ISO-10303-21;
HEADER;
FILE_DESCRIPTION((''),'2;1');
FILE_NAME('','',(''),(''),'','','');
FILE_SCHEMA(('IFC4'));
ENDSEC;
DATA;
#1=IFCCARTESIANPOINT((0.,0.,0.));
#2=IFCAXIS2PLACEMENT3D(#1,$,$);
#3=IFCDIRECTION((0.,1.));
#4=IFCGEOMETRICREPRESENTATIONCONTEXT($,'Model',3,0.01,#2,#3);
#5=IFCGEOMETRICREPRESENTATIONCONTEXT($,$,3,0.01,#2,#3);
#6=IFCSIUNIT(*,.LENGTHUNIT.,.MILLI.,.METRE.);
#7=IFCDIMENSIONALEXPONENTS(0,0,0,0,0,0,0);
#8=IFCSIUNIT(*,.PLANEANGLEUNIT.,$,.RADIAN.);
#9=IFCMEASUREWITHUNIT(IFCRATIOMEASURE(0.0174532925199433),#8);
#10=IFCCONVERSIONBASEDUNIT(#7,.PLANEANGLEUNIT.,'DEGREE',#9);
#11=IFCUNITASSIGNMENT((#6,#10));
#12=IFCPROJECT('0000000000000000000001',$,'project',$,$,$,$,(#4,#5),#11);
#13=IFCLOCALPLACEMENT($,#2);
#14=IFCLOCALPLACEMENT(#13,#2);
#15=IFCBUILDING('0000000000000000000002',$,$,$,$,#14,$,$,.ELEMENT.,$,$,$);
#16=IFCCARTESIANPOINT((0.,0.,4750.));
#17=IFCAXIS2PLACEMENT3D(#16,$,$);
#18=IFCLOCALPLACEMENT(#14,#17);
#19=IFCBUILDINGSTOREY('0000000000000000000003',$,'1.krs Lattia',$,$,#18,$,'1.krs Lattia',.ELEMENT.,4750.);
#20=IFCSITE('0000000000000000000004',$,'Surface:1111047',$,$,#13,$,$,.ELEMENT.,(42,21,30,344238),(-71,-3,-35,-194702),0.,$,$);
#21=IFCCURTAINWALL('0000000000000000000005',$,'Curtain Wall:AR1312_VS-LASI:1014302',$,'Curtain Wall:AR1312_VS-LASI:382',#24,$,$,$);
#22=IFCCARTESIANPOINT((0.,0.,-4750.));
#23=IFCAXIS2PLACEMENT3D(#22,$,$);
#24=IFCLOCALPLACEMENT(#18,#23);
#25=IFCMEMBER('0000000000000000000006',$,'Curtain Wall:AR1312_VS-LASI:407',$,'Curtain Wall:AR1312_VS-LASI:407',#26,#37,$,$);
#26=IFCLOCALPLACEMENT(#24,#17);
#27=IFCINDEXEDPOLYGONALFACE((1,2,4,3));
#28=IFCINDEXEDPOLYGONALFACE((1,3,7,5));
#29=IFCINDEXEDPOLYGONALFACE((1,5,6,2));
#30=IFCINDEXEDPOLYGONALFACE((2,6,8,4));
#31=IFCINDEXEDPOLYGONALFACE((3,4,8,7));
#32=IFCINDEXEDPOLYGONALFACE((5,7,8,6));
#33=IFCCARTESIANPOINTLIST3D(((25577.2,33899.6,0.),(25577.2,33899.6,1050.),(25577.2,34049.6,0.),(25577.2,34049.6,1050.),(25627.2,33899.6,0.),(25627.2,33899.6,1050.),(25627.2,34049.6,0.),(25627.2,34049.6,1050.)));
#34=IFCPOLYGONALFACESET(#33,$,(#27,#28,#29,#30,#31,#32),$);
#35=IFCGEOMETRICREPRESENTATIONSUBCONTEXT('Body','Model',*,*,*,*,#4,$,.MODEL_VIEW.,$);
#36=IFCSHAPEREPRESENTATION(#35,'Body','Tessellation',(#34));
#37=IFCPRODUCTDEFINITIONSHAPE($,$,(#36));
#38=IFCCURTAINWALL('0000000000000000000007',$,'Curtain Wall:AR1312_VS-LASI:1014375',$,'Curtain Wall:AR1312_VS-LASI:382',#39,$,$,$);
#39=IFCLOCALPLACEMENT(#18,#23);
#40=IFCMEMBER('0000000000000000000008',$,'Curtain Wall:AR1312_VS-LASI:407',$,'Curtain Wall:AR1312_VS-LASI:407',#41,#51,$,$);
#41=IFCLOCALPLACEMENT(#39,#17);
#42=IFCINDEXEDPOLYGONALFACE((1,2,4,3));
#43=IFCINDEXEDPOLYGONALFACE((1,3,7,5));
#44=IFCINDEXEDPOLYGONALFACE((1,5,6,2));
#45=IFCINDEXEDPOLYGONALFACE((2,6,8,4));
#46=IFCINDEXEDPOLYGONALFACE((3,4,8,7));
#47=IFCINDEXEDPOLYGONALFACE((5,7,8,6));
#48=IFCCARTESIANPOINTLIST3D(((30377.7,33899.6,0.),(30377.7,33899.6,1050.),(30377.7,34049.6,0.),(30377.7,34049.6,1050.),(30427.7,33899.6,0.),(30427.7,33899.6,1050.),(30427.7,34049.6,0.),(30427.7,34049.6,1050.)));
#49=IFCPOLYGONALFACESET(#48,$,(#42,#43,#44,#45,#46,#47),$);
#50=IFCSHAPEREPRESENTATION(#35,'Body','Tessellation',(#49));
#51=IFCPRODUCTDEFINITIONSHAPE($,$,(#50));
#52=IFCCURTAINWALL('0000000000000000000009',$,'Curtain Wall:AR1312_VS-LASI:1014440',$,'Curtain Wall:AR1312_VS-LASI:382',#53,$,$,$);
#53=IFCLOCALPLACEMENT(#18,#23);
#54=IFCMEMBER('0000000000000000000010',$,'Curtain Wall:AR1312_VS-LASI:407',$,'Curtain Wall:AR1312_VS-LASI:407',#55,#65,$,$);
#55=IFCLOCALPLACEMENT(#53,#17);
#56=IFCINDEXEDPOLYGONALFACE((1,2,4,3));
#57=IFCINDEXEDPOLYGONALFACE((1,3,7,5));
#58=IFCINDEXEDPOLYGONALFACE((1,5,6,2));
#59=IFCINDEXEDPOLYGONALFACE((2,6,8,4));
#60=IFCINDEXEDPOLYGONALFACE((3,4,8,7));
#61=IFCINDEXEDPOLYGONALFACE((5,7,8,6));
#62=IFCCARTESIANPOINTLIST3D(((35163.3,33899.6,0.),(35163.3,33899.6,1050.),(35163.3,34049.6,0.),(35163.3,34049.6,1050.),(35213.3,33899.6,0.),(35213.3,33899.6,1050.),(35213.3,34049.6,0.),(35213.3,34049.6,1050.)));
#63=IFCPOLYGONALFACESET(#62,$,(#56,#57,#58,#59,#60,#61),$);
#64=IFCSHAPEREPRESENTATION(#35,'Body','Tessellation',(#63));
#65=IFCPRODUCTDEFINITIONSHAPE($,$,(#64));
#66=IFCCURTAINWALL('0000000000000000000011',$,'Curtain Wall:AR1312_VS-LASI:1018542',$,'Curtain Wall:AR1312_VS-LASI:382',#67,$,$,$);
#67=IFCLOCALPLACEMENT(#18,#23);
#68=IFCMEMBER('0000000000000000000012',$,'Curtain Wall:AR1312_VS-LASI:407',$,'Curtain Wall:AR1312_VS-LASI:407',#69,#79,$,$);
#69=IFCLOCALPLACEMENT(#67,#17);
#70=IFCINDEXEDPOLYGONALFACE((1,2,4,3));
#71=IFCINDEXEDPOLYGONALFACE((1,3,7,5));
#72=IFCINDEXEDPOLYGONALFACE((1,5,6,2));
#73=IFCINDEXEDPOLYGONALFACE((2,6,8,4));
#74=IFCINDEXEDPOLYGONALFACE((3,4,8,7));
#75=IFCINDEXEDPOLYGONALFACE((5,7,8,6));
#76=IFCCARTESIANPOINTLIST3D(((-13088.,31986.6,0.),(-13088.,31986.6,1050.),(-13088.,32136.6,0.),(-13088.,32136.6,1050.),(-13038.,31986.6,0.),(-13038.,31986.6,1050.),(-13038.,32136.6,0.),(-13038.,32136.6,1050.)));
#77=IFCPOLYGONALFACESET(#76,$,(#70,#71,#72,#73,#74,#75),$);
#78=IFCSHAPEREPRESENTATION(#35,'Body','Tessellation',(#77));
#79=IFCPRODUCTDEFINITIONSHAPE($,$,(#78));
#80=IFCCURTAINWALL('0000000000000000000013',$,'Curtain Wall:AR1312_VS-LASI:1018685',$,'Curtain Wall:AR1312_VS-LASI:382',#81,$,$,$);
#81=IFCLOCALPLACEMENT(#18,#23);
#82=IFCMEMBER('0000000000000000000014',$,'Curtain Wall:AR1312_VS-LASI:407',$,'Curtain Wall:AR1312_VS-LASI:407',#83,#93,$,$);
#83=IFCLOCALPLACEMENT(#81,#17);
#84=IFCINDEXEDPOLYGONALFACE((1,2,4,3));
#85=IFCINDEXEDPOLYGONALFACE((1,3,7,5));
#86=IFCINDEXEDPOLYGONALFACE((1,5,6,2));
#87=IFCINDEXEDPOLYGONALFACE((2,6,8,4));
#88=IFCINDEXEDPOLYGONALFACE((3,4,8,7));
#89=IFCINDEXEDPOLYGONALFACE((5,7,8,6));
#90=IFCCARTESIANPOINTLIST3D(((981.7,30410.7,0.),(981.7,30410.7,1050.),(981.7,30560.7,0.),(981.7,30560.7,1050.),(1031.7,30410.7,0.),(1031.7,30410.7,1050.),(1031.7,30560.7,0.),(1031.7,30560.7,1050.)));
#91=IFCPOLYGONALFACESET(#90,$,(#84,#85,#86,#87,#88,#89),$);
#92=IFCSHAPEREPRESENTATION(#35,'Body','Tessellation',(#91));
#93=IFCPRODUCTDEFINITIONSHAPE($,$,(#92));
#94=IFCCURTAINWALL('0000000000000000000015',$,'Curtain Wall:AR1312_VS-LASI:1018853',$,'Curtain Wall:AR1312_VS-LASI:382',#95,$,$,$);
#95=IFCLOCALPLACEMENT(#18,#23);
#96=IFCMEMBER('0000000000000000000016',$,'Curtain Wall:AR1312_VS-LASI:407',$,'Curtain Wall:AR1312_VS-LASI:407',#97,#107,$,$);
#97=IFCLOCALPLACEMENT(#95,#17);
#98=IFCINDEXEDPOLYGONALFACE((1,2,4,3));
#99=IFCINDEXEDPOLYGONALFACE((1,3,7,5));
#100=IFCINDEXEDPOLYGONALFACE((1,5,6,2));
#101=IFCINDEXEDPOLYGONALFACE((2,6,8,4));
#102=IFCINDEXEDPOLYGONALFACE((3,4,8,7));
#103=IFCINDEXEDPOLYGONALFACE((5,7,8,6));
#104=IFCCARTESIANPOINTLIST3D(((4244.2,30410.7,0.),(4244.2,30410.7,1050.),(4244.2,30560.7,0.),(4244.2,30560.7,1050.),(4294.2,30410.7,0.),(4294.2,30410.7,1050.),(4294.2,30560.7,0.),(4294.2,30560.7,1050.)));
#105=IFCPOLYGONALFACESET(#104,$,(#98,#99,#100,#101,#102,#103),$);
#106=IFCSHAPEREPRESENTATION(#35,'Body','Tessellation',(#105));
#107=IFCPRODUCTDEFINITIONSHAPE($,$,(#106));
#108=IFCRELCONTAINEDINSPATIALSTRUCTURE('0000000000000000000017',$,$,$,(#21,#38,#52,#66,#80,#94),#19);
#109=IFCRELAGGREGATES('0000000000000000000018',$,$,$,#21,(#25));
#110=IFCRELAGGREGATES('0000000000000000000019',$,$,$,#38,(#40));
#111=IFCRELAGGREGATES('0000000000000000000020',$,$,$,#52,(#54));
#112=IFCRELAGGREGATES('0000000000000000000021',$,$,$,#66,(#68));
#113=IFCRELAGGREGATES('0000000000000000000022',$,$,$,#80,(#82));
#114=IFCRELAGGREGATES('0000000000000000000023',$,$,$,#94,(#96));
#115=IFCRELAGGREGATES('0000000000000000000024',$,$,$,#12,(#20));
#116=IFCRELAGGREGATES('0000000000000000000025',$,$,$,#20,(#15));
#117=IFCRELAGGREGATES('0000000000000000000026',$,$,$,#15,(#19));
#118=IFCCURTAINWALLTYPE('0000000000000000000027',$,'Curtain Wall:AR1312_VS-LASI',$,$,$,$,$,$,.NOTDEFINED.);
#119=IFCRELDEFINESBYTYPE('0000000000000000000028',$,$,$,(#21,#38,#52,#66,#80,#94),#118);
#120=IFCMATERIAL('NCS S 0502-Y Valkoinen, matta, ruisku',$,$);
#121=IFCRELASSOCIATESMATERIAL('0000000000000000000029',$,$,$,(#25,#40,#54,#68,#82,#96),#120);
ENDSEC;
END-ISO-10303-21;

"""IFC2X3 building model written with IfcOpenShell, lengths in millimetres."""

from ifc_helpers import new_model, entity, si_unit, converted_unit, direction, frame, frame_2d, origin, origin_2d_with_axis, place, context, subcontext, project, spatial, rectangle, extrude, material, type_object, element, aggregate, save


model = new_model("IFC2X3")

# Units and contexts
model_context = context("Model", 3, precision=0.01, world=origin(), true_north=direction((0.0, 1.0)))
context_of_model = context(None, 3, precision=0.01, world=origin(), true_north=direction((0.0, 1.0)))
body_context = subcontext(model_context, "Body", "Model", "MODEL_VIEW")
ifc_project = project(units=[si_unit("LENGTHUNIT", "METRE", prefix="MILLI"), converted_unit("PLANEANGLEUNIT", "DEGREE", entity("IfcRatioMeasure", 0.0174532925199433), si_unit("PLANEANGLEUNIT", "RADIAN"), dimensions=[0, 0, 0, 0, 0, 0, 0])], contexts=[model_context, context_of_model])

# Site, building, storey
site_placement = place(None, origin())
site = spatial("IfcSite", under=ifc_project, at=site_placement, Name="Surface:1111047", CompositionType="ELEMENT", RefLatitude=(42, 21, 30, 344238), RefLongitude=(-71, -3, -35, -194702), RefElevation=0.0)
building_placement = place(site_placement, origin())
building = spatial("IfcBuilding", under=site, at=building_placement, CompositionType="ELEMENT")
storey_placement = place(building_placement, frame((0.0, 0.0, 4750.0)))
storey = spatial("IfcBuildingStorey", under=building, at=storey_placement, Name="1.krs Lattia", LongName="1.krs Lattia", CompositionType="ELEMENT", Elevation=4750.0)

# Curtain walls, members
curtain_wall_type = type_object("IfcCurtainWallType", Name="Curtain Wall:AR1312_VS-LASI", PredefinedType="NOTDEFINED")
curtain_wall_1_placement = place(storey_placement, frame((0.0, 0.0, -4750.0)))
curtain_wall_1 = element("IfcCurtainWall", 1, at=curtain_wall_1_placement, inside=storey, type_object=curtain_wall_type, Name="Curtain Wall:AR1312_VS-LASI:1014302", ObjectType="Curtain Wall:AR1312_VS-LASI:382")
ifc_material = material(Name="NCS S 0502-Y Valkoinen, matta, ruisku")
member_1_placement = place(curtain_wall_1_placement, frame((0.0, 0.0, 4750.0)))
member_1 = element("IfcMember", 2, at=member_1_placement, material=ifc_material, Name="Curtain Wall:AR1312_VS-LASI:407", ObjectType="Curtain Wall:AR1312_VS-LASI:407", context=body_context, shape_type="SweptSolid", body=[
    extrude(rectangle(XDim=50.0, YDim=150.0, at=frame_2d((0.0, 0.0), x_axis=(1.0, 0.0))), frame((25602.2, 33974.6, 0.0), z_axis=(0.0, 0.0, 1.0), x_axis=(-1.0, 0.0, 0.0)), (0.0, 0.0, 1.0), 1050.0),
])
aggregate(curtain_wall_1, [member_1])
curtain_wall_2_placement = place(storey_placement, frame((0.0, 0.0, -4750.0)))
curtain_wall_2 = element("IfcCurtainWall", 3, at=curtain_wall_2_placement, inside=storey, type_object=curtain_wall_type, Name="Curtain Wall:AR1312_VS-LASI:1014375", ObjectType="Curtain Wall:AR1312_VS-LASI:382")
member_2_placement = place(curtain_wall_2_placement, frame((0.0, 0.0, 4750.0)))
member_2 = element("IfcMember", 4, at=member_2_placement, material=ifc_material, Name="Curtain Wall:AR1312_VS-LASI:407", ObjectType="Curtain Wall:AR1312_VS-LASI:407", context=body_context, shape_type="SweptSolid", body=[
    extrude(rectangle(XDim=50.0, YDim=150.0, at=frame_2d((0.0, 0.0), x_axis=(1.0, 0.0))), frame((30402.7, 33974.6, 0.0), z_axis=(0.0, 0.0, 1.0), x_axis=(-1.0, 0.0, 0.0)), (0.0, 0.0, 1.0), 1050.0),
])
aggregate(curtain_wall_2, [member_2])
curtain_wall_3_placement = place(storey_placement, frame((0.0, 0.0, -4750.0)))
curtain_wall_3 = element("IfcCurtainWall", 5, at=curtain_wall_3_placement, inside=storey, type_object=curtain_wall_type, Name="Curtain Wall:AR1312_VS-LASI:1014440", ObjectType="Curtain Wall:AR1312_VS-LASI:382")
member_3_placement = place(curtain_wall_3_placement, frame((0.0, 0.0, 4750.0)))
member_3 = element("IfcMember", 6, at=member_3_placement, material=ifc_material, Name="Curtain Wall:AR1312_VS-LASI:407", ObjectType="Curtain Wall:AR1312_VS-LASI:407", context=body_context, shape_type="SweptSolid", body=[
    extrude(rectangle(XDim=50.0, YDim=150.0, at=frame_2d((0.0, 0.0), x_axis=(1.0, 0.0))), frame((35188.3, 33974.6, 0.0), z_axis=(0.0, 0.0, 1.0), x_axis=(-1.0, 0.0, 0.0)), (0.0, 0.0, 1.0), 1050.0),
])
aggregate(curtain_wall_3, [member_3])
curtain_wall_4_placement = place(storey_placement, frame((0.0, 0.0, -4750.0)))
curtain_wall_4 = element("IfcCurtainWall", 7, at=curtain_wall_4_placement, inside=storey, type_object=curtain_wall_type, Name="Curtain Wall:AR1312_VS-LASI:1018542", ObjectType="Curtain Wall:AR1312_VS-LASI:382")
member_4_placement = place(curtain_wall_4_placement, frame((0.0, 0.0, 4750.0)))
member_4 = element("IfcMember", 8, at=member_4_placement, material=ifc_material, Name="Curtain Wall:AR1312_VS-LASI:407", ObjectType="Curtain Wall:AR1312_VS-LASI:407", context=body_context, shape_type="SweptSolid", body=[
    extrude(rectangle(XDim=50.0, YDim=150.0, at=frame_2d((0.0, 0.0), x_axis=(1.0, 0.0))), frame((-13063.0, 32061.6, 0.0), z_axis=(0.0, 0.0, 1.0), x_axis=(-1.0, 0.0, 0.0)), (0.0, 0.0, 1.0), 1050.0),
])
aggregate(curtain_wall_4, [member_4])
curtain_wall_5_placement = place(storey_placement, frame((0.0, 0.0, -4750.0)))
curtain_wall_5 = element("IfcCurtainWall", 9, at=curtain_wall_5_placement, inside=storey, type_object=curtain_wall_type, Name="Curtain Wall:AR1312_VS-LASI:1018685", ObjectType="Curtain Wall:AR1312_VS-LASI:382")
member_5_placement = place(curtain_wall_5_placement, frame((0.0, 0.0, 4750.0)))
member_5 = element("IfcMember", 10, at=member_5_placement, material=ifc_material, Name="Curtain Wall:AR1312_VS-LASI:407", ObjectType="Curtain Wall:AR1312_VS-LASI:407", context=body_context, shape_type="SweptSolid", body=[
    extrude(rectangle(XDim=50.0, YDim=150.0, at=origin_2d_with_axis()), frame((1006.7, 30485.7, 0.0), z_axis=(0.0, 0.0, 1.0), x_axis=(-1.0, 0.0, 0.0)), (0.0, 0.0, 1.0), 1050.0),
])
aggregate(curtain_wall_5, [member_5])
curtain_wall_6_placement = place(storey_placement, frame((0.0, 0.0, -4750.0)))
curtain_wall_6 = element("IfcCurtainWall", 11, at=curtain_wall_6_placement, inside=storey, type_object=curtain_wall_type, Name="Curtain Wall:AR1312_VS-LASI:1018853", ObjectType="Curtain Wall:AR1312_VS-LASI:382")
member_6_placement = place(curtain_wall_6_placement, frame((0.0, 0.0, 4750.0)))
member_6 = element("IfcMember", 12, at=member_6_placement, material=ifc_material, Name="Curtain Wall:AR1312_VS-LASI:407", ObjectType="Curtain Wall:AR1312_VS-LASI:407", context=body_context, shape_type="SweptSolid", body=[
    extrude(rectangle(XDim=50.0, YDim=150.0, at=frame_2d((0.0, 0.0), x_axis=(1.0, 0.0))), frame((4269.2, 30485.7, 0.0), z_axis=(0.0, 0.0, 1.0), x_axis=(-1.0, 0.0, 0.0)), (0.0, 0.0, 1.0), 1050.0),
])
aggregate(curtain_wall_6, [member_6])

save(model, "model.ifc")
